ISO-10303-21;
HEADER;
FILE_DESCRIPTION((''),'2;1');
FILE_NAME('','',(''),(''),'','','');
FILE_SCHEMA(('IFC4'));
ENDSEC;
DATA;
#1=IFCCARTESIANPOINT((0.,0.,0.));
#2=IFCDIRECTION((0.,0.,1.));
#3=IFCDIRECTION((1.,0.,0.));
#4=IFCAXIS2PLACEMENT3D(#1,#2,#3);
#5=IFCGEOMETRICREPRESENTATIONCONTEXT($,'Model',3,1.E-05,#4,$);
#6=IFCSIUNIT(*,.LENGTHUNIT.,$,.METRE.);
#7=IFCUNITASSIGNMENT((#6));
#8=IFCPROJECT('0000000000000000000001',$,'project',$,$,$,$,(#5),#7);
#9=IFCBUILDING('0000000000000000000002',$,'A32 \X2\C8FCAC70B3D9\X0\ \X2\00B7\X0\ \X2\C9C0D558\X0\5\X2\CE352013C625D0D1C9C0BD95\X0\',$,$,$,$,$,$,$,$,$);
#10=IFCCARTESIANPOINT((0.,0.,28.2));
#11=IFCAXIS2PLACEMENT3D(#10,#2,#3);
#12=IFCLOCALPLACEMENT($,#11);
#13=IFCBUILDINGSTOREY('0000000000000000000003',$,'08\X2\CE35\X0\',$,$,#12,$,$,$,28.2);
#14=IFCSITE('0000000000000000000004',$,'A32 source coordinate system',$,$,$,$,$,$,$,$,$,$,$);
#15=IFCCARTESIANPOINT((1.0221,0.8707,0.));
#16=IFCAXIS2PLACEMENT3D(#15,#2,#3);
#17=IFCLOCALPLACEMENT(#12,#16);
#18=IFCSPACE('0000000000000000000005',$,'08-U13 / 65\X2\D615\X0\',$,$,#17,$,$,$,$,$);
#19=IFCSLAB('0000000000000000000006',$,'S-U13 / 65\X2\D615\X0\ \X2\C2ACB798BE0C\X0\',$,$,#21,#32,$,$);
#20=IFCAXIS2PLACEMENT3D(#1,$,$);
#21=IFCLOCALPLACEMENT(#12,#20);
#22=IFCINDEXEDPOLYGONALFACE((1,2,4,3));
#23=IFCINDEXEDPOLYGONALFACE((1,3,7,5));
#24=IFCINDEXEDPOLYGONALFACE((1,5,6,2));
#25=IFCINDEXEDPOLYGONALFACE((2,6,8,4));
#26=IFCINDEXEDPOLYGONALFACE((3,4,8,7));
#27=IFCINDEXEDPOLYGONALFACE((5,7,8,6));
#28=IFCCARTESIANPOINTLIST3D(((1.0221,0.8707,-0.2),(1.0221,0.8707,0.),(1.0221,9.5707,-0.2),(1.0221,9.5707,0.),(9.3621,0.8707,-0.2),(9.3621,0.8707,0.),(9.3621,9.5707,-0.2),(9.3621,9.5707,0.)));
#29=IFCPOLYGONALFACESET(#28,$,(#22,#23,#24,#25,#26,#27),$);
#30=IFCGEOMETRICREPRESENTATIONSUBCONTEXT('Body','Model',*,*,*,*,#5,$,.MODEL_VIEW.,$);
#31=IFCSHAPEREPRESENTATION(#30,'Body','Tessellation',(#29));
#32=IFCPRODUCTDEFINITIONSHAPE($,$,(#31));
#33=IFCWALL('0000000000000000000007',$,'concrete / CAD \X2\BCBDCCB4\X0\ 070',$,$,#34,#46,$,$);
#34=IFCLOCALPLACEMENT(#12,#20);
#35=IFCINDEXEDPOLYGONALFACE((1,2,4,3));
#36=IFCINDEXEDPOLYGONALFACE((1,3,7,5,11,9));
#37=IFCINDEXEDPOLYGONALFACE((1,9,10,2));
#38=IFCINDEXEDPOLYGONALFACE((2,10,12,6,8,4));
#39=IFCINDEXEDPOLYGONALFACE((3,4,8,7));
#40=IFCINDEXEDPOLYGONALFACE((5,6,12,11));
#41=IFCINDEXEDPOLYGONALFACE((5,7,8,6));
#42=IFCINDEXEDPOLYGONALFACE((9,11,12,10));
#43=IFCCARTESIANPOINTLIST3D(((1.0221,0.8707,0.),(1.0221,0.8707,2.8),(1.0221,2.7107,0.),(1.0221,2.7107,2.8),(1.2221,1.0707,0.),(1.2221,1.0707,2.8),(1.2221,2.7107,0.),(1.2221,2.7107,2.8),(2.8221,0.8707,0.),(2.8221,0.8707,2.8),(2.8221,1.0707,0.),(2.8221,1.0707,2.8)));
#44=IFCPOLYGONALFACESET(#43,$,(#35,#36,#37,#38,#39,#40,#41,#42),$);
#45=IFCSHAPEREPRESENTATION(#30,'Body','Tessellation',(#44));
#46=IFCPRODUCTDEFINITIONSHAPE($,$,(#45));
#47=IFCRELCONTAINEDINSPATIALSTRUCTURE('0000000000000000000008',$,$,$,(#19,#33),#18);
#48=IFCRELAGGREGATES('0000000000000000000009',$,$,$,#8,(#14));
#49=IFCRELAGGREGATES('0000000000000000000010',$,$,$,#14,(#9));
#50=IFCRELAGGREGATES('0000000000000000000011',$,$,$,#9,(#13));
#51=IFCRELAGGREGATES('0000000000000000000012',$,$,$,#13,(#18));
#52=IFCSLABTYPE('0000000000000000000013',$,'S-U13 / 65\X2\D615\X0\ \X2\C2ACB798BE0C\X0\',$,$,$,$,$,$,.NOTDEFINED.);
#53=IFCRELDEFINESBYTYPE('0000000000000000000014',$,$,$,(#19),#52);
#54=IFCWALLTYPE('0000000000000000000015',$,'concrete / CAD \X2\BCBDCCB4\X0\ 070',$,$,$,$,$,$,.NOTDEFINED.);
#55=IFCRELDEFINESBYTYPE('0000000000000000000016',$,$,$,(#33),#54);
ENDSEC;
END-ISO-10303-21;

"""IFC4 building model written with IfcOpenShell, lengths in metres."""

from ifc_helpers import new_model, si_unit, frame, origin, origin_with_axes, place, context, subcontext, project, spatial, polyline, outline, extrude, source, transform, mapped, type_object, type_shapes, element, save


model = new_model("IFC4")

# Units and contexts
model_context = context("Model", 3, precision=1e-05, world=origin_with_axes())
body_context = subcontext(model_context, "Body", "Model", "MODEL_VIEW")
ifc_project = project(units=[si_unit("LENGTHUNIT", "METRE")], contexts=[model_context])

# Site, building, storey, space
storey_placement = place(None, frame((0.0, 0.0, 28.2), z_axis=(0.0, 0.0, 1.0), x_axis=(1.0, 0.0, 0.0)))
space_placement = place(storey_placement, frame((1.0221, 0.8707, 0.0), z_axis=(0.0, 0.0, 1.0), x_axis=(1.0, 0.0, 0.0)))
site = spatial("IfcSite", under=ifc_project, Name="A32 source coordinate system")
building = spatial("IfcBuilding", under=site, Name="A32 주거동 · 지하5층–옥탑지붕")
storey = spatial("IfcBuildingStorey", under=building, at=storey_placement, Name="08층", Elevation=28.2)
space = spatial("IfcSpace", under=storey, at=space_placement, Name="08-U13 / 65형")

# Slab
slab_type = type_object("IfcSlabType", Name="S-U13 / 65형 슬래브", PredefinedType="NOTDEFINED")
shared_shape_1 = source(origin(), body_context, "Body", "SweptSolid", [
    extrude(outline(polyline([(0.0, 0.0), (0.0, 8.7), (8.34, 8.7), (8.34, 0.0), (0.0, 0.0)])), frame((0.0, 0.0, -0.2)), (0.0, 0.0, 1.0), 0.2),
])
type_shapes(slab_type, [shared_shape_1])
slab_placement = place(space_placement, origin_with_axes())
element("IfcSlab", 1, at=slab_placement, inside=space, type_object=slab_type, Name="S-U13 / 65형 슬래브", context=body_context, shape_type="MappedRepresentation", body=[
    mapped(shared_shape_1, transform((0.0, 0.0, 0.0), scale=1.0)),
])

# Wall
wall_type_1 = type_object("IfcWallType", Name="concrete / CAD 벽체 070", PredefinedType="NOTDEFINED")
shared_shape_2 = source(origin(), body_context, "Body", "SweptSolid", [
    extrude(outline(polyline([(0.2, 1.84), (0.2, 0.2), (1.8, 0.2), (1.8, 0.0), (0.0, 0.0), (0.0, 1.84), (0.2, 1.84)])), origin(), (0.0, 0.0, 1.0), 2.8),
])
type_shapes(wall_type_1, [shared_shape_2])
wall_1_placement = place(space_placement, origin_with_axes())
element("IfcWall", 2, at=wall_1_placement, inside=space, type_object=wall_type_1, Name="concrete / CAD 벽체 070", context=body_context, shape_type="MappedRepresentation", body=[
    mapped(shared_shape_2, transform((0.0, 0.0, 0.0), scale=1.0)),
])

save(model, "model.ifc")
